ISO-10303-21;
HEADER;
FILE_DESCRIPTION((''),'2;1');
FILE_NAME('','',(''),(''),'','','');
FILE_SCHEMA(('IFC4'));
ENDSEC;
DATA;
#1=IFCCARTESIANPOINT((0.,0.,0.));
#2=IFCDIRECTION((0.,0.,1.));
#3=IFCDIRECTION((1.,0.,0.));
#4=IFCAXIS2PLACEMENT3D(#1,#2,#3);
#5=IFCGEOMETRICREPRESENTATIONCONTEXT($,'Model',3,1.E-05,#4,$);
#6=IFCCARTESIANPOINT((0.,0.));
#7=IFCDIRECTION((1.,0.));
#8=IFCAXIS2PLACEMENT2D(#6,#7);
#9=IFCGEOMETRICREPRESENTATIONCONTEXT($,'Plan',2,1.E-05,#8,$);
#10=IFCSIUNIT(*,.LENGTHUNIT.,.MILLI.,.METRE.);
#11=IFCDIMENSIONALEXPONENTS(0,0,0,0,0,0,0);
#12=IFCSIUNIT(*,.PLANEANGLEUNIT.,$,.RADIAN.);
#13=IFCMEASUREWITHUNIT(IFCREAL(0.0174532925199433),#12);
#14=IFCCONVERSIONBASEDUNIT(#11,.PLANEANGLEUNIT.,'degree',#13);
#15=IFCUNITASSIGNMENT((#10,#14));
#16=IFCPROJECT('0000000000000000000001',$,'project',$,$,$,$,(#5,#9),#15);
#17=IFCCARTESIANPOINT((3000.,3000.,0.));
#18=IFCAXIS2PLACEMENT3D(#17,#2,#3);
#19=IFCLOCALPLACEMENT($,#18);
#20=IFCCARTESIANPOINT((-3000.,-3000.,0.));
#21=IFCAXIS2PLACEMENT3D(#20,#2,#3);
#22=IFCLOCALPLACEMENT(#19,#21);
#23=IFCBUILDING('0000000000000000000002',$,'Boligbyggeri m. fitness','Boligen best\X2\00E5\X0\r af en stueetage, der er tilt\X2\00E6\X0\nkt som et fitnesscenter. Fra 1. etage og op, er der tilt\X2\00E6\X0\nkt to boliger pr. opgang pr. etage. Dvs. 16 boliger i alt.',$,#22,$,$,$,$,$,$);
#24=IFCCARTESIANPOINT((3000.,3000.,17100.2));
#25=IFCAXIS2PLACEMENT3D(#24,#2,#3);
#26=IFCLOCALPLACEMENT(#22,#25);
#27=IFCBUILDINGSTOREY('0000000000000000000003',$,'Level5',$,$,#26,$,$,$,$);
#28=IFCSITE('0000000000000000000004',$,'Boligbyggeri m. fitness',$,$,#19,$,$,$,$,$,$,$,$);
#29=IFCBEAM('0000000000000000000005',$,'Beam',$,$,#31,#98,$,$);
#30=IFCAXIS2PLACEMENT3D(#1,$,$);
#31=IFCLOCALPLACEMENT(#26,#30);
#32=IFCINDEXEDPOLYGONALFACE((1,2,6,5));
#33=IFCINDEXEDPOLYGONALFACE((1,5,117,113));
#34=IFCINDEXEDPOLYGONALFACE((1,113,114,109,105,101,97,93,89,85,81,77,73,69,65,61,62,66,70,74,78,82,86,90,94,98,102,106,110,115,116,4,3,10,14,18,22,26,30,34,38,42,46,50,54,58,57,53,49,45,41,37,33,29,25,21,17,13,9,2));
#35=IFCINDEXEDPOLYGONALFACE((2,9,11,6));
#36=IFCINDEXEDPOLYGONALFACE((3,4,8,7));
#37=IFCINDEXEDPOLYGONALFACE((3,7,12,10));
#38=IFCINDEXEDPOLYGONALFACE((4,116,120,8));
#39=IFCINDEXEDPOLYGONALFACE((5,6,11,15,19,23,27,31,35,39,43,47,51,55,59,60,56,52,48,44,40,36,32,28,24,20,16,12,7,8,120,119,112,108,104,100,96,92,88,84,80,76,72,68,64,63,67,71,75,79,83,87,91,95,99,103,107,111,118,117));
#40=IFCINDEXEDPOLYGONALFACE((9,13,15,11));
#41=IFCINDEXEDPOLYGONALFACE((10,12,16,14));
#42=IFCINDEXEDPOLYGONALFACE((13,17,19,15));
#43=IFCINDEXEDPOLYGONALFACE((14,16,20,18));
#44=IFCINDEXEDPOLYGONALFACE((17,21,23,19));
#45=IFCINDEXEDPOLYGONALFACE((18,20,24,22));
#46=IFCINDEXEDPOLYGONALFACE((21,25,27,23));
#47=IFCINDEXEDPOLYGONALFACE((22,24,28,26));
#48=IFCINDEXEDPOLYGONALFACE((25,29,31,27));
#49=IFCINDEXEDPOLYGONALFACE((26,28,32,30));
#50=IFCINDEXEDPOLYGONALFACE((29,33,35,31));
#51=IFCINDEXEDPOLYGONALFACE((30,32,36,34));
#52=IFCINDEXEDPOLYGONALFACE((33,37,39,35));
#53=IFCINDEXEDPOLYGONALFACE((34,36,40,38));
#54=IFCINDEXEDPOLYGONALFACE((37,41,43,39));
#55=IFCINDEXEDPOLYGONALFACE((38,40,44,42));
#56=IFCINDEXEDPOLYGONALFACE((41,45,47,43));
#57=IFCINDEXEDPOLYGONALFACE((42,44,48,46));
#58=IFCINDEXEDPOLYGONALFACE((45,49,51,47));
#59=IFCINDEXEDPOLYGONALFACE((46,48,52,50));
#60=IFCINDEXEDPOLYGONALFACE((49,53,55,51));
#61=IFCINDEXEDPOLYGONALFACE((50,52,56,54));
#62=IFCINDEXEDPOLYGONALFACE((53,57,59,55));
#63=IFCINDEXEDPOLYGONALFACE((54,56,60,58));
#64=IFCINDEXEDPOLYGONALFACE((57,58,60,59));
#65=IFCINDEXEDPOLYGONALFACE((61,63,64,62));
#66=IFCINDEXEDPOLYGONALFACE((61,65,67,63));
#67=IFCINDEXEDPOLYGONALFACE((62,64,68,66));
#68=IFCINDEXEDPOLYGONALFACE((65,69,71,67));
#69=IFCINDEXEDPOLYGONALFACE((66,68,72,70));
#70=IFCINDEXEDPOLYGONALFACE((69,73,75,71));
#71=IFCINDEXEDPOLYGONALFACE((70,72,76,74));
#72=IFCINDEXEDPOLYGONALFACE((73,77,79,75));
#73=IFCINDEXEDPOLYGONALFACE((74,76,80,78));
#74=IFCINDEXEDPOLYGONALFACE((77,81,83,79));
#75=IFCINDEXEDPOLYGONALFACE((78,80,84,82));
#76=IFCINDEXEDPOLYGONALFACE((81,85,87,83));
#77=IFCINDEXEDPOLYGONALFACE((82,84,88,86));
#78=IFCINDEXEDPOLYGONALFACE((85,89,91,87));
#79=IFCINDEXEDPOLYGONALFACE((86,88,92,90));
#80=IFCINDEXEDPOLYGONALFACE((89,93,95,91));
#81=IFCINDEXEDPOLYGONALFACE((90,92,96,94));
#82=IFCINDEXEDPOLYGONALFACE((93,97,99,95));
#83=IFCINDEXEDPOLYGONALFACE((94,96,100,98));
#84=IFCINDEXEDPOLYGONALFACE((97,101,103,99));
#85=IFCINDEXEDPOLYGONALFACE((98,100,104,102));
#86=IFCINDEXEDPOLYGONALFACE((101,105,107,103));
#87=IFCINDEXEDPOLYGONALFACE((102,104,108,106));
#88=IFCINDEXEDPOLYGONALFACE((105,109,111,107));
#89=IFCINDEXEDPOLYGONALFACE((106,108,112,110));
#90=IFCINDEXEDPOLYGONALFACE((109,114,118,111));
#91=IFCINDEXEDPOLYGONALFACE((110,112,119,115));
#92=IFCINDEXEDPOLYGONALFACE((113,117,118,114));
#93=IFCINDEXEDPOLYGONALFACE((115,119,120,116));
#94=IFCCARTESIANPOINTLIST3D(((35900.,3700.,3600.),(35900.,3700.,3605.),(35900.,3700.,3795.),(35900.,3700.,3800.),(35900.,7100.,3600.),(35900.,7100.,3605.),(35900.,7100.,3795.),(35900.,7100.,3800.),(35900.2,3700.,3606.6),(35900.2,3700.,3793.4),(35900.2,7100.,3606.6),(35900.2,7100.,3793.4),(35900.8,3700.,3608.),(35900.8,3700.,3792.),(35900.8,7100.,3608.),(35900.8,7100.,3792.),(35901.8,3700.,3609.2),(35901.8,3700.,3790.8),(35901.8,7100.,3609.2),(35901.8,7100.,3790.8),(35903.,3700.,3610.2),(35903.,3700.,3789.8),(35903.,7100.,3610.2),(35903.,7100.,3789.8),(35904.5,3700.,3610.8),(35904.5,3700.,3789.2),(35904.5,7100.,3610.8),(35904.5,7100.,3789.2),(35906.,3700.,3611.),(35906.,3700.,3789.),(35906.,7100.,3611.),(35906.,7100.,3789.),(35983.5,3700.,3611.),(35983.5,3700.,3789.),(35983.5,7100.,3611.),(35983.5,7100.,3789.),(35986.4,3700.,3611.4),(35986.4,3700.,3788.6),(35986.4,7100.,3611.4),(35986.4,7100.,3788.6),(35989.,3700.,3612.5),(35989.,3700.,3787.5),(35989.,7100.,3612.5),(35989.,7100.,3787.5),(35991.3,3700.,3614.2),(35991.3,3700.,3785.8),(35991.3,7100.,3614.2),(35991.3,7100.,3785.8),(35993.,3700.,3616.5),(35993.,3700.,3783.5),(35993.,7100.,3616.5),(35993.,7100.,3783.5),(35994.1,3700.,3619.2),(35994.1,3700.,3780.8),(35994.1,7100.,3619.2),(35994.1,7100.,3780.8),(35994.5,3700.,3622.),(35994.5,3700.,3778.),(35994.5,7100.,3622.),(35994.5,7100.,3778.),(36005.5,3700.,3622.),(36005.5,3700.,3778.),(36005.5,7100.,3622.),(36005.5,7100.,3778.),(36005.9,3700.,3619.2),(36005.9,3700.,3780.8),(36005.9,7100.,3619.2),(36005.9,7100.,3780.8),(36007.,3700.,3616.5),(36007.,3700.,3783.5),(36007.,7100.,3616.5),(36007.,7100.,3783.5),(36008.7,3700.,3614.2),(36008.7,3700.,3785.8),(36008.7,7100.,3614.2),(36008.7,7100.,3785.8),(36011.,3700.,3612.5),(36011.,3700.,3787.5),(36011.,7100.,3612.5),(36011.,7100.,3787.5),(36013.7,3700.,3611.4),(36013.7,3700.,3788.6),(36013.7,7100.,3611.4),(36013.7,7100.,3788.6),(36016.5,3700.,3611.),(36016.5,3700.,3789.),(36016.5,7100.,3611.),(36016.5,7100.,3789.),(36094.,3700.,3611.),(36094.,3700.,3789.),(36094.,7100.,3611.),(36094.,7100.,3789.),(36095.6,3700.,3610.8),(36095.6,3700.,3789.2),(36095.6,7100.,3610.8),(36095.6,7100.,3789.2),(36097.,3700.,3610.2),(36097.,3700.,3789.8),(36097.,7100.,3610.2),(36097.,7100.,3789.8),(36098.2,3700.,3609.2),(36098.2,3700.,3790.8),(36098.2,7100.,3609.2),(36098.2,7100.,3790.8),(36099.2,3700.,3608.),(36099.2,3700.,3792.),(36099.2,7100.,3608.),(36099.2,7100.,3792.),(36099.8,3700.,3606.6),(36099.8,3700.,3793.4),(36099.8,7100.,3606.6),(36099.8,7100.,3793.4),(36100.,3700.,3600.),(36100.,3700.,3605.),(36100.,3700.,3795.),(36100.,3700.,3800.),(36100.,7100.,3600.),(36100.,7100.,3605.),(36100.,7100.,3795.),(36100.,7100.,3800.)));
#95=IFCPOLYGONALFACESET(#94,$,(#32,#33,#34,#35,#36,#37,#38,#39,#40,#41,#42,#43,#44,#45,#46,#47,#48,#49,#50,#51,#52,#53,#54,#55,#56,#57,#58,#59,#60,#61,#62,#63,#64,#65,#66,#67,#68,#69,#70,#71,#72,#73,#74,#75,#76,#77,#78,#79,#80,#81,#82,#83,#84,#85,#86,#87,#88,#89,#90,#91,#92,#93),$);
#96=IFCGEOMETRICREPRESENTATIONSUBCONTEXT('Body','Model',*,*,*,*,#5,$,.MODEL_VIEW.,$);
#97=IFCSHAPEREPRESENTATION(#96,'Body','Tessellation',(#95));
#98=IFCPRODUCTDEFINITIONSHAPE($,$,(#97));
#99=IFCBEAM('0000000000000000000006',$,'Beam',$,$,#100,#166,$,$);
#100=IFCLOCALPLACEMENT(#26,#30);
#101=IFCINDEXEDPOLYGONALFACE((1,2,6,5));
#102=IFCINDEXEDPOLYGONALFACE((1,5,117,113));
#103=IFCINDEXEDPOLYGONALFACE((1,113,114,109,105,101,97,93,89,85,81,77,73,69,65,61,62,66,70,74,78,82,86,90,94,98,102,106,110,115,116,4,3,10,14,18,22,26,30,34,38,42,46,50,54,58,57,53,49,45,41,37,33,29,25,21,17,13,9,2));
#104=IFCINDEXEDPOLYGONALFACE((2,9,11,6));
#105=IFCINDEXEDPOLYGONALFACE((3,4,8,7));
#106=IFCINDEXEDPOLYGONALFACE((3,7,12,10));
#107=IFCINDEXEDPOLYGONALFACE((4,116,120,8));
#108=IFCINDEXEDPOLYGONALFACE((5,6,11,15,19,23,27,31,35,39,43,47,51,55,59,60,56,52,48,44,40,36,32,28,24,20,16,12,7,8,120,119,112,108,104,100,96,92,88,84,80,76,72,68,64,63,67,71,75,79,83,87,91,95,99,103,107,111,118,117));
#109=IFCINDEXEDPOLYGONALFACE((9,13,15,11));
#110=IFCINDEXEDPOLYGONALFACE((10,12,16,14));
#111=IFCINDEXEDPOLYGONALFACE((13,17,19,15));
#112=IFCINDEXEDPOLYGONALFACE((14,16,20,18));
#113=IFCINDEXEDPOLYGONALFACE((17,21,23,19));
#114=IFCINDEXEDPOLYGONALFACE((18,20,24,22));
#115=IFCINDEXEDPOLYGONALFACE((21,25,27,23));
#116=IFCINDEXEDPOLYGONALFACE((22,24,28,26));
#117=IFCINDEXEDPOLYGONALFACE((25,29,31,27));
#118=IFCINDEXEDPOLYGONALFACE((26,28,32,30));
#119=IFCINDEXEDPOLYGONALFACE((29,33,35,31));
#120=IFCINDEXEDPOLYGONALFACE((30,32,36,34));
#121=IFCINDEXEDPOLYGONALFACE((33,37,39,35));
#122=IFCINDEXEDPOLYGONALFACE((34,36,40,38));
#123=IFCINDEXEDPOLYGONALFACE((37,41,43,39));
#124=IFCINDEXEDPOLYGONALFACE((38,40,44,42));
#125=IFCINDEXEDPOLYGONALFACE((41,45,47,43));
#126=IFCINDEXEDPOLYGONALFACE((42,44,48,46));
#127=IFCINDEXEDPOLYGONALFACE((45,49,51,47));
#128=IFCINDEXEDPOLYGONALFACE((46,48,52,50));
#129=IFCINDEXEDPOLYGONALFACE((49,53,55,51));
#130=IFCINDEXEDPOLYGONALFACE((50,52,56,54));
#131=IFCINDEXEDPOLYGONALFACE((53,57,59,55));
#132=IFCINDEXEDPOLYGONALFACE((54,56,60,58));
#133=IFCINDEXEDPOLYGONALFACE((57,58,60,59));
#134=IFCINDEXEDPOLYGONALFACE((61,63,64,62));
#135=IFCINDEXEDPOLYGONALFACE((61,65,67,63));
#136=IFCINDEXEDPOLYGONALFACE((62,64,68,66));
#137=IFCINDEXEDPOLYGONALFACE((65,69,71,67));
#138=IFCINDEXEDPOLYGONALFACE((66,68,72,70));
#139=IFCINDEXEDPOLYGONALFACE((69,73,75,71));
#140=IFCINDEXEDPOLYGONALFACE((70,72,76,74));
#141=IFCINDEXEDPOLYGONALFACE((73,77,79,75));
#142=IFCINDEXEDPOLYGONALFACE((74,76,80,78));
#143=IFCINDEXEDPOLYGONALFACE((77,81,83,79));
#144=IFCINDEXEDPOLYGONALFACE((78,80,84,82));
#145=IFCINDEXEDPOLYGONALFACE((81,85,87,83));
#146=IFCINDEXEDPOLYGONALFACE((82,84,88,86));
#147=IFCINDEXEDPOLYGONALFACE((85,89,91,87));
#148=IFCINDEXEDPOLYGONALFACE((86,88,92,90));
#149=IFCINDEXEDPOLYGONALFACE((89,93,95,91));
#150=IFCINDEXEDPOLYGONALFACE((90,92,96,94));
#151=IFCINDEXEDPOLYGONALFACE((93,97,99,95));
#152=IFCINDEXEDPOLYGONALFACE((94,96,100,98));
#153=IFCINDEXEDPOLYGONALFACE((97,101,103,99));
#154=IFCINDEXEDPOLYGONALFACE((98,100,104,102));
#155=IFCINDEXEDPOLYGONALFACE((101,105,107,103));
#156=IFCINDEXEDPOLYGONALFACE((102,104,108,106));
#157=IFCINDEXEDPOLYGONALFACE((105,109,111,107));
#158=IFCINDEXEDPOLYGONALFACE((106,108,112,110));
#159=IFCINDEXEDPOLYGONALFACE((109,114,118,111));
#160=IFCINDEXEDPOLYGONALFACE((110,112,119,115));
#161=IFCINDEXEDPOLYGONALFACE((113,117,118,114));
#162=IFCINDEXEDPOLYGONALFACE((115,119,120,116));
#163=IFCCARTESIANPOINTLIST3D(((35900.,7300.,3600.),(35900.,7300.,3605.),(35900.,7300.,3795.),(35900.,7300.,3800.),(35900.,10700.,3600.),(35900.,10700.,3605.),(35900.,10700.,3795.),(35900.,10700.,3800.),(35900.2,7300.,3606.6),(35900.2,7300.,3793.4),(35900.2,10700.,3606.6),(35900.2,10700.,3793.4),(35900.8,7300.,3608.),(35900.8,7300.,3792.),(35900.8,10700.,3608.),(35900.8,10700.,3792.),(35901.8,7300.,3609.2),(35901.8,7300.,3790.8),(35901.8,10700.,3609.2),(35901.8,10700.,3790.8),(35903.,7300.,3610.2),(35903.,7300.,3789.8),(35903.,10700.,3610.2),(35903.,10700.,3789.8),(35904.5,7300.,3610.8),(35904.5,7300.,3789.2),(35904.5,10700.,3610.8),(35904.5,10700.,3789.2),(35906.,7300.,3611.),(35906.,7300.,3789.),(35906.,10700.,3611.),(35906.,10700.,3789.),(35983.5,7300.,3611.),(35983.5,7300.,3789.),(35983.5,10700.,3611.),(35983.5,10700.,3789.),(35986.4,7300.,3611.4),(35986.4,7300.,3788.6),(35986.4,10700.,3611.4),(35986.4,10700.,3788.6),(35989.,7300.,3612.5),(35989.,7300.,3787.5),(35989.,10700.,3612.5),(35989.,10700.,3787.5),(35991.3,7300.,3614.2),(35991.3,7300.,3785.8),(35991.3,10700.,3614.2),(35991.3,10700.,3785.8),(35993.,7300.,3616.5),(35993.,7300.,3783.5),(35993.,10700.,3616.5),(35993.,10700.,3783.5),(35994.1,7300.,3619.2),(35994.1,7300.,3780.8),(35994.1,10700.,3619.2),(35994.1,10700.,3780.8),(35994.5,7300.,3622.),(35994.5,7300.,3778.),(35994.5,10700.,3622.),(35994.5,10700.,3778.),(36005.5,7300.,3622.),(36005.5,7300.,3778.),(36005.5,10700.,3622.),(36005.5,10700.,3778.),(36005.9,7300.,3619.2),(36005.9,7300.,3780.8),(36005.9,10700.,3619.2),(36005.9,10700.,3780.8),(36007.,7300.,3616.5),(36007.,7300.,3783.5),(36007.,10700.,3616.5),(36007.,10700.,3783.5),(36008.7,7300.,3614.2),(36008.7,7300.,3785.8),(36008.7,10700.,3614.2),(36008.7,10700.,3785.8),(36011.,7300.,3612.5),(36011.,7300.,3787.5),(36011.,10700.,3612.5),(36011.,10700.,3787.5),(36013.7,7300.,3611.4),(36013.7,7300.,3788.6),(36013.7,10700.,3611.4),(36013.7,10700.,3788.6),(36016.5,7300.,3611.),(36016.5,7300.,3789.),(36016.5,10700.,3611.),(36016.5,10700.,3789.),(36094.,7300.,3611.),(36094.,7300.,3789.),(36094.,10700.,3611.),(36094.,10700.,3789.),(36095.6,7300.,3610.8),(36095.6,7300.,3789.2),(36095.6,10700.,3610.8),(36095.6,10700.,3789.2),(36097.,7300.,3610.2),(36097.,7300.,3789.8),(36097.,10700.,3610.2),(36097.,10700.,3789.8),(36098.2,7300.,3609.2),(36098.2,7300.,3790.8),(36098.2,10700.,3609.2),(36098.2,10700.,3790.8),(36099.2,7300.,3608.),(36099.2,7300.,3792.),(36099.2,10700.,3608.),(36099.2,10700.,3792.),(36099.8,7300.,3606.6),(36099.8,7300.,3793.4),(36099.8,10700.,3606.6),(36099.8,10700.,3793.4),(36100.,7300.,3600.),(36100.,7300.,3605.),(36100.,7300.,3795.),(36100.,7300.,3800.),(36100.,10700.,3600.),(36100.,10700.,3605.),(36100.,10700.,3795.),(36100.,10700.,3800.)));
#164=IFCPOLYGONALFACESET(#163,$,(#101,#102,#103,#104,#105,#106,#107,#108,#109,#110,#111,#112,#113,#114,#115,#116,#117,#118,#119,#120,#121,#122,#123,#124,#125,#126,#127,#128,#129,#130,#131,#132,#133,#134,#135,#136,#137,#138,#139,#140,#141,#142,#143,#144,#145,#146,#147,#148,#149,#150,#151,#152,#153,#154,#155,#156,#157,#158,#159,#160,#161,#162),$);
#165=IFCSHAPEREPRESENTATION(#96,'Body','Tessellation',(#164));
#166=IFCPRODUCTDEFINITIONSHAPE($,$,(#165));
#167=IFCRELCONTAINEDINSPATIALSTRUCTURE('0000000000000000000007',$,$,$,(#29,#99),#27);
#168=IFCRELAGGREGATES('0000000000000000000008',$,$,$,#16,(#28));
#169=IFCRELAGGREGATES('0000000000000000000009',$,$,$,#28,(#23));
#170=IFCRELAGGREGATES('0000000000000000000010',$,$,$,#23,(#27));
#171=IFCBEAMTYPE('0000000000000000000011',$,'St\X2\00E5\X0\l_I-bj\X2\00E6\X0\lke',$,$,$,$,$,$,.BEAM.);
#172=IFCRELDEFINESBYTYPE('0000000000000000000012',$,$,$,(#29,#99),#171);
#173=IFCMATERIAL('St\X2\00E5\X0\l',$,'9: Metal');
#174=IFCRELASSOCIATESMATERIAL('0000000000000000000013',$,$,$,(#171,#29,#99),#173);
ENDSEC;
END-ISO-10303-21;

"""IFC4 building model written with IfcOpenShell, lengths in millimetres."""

from ifc_helpers import new_model, entity, si_unit, converted_unit, frame, origin_with_axes, origin_2d_with_axis, place, context, subcontext, project, spatial, i_section, extrude, material, material_profile, profile_set, profile_usage, type_object, element, save


model = new_model("IFC4")

# Units and contexts
model_context = context("Model", 3, precision=1e-05, world=origin_with_axes())
plan_context = context("Plan", 2, precision=1e-05, world=origin_2d_with_axis())
body_context = subcontext(model_context, "Body", "Model", "MODEL_VIEW")
ifc_project = project(units=[si_unit("LENGTHUNIT", "METRE", prefix="MILLI"), converted_unit("PLANEANGLEUNIT", "degree", entity("IfcReal", 0.0174532925199433), si_unit("PLANEANGLEUNIT", "RADIAN"), dimensions=[0, 0, 0, 0, 0, 0, 0])], contexts=[model_context, plan_context])

# Site, building, storey
site_placement = place(None, frame((3000.0, 3000.0, 0.0), z_axis=(0.0, 0.0, 1.0), x_axis=(1.0, 0.0, 0.0)))
site = spatial("IfcSite", under=ifc_project, at=site_placement, Name="Boligbyggeri m. fitness")
building_placement = place(site_placement, frame((-3000.0, -3000.0, 0.0), z_axis=(0.0, 0.0, 1.0), x_axis=(1.0, 0.0, 0.0)))
building = spatial("IfcBuilding", under=site, at=building_placement, Name="Boligbyggeri m. fitness", Description="Boligen består af en stueetage, der er tiltænkt som et fitnesscenter. Fra 1. etage og op, er der tiltænkt to boliger pr. opgang pr. etage. Dvs. 16 boliger i alt.")
storey_placement = place(building_placement, frame((3000.0, 3000.0, 17100.2), z_axis=(0.0, 0.0, 1.0), x_axis=(1.0, 0.0, 0.0)))
storey = spatial("IfcBuildingStorey", under=building, at=storey_placement, Name="Level5")

# Beams
ifc_material_1 = material(Name="Stål", Category="9: Metal")
ifc_material_profile_1 = material_profile(ifc_material_1, i_section(OverallWidth=200.0, OverallDepth=200.0, WebThickness=11.0, FlangeThickness=11.0, FilletRadius=11.0, FlangeEdgeRadius=6.0), Name="Stål", Category="9: Metal")
ifc_profile_set_1 = profile_set([ifc_material_profile_1], Name="NY_I-Profil")
beam_type = type_object("IfcBeamType", Name="Stål_I-bjælke", PredefinedType="BEAM", material=ifc_profile_set_1)
ifc_profile_usage_1 = profile_usage(ifc_profile_set_1, cardinal=9)
beam_1_placement = place(storey_placement, frame((36100.0, 3700.0, 3800.0), z_axis=(0.0, 1.0, 0.0), x_axis=(-1.0, 0.0, 0.0)))
element("IfcBeam", 1, at=beam_1_placement, inside=storey, type_object=beam_type, material=ifc_profile_usage_1, Name="Beam", context=body_context, shape_type="SweptSolid", body=[
    extrude(i_section(OverallWidth=200.0, OverallDepth=200.0, WebThickness=11.0, FlangeThickness=11.0, FilletRadius=11.0, FlangeEdgeRadius=6.0), frame((100.0, -100.0, 0.0), z_axis=(0.0, 0.0, 1.0), x_axis=(1.0, 0.0, 0.0)), (0.0, 0.0, 1.0), 3400.0),
])
ifc_profile_usage_2 = profile_usage(ifc_profile_set_1, cardinal=9)
beam_2_placement = place(storey_placement, frame((36100.0, 7300.0, 3800.0), z_axis=(0.0, 1.0, 0.0), x_axis=(-1.0, 0.0, 0.0)))
element("IfcBeam", 2, at=beam_2_placement, inside=storey, type_object=beam_type, material=ifc_profile_usage_2, Name="Beam", context=body_context, shape_type="SweptSolid", body=[
    extrude(i_section(OverallWidth=200.0, OverallDepth=200.0, WebThickness=11.0, FlangeThickness=11.0, FilletRadius=11.0, FlangeEdgeRadius=6.0), frame((100.0, -100.0, 0.0), z_axis=(0.0, 0.0, 1.0), x_axis=(1.0, 0.0, 0.0)), (0.0, 0.0, 1.0), 3400.0),
])

save(model, "model.ifc")
